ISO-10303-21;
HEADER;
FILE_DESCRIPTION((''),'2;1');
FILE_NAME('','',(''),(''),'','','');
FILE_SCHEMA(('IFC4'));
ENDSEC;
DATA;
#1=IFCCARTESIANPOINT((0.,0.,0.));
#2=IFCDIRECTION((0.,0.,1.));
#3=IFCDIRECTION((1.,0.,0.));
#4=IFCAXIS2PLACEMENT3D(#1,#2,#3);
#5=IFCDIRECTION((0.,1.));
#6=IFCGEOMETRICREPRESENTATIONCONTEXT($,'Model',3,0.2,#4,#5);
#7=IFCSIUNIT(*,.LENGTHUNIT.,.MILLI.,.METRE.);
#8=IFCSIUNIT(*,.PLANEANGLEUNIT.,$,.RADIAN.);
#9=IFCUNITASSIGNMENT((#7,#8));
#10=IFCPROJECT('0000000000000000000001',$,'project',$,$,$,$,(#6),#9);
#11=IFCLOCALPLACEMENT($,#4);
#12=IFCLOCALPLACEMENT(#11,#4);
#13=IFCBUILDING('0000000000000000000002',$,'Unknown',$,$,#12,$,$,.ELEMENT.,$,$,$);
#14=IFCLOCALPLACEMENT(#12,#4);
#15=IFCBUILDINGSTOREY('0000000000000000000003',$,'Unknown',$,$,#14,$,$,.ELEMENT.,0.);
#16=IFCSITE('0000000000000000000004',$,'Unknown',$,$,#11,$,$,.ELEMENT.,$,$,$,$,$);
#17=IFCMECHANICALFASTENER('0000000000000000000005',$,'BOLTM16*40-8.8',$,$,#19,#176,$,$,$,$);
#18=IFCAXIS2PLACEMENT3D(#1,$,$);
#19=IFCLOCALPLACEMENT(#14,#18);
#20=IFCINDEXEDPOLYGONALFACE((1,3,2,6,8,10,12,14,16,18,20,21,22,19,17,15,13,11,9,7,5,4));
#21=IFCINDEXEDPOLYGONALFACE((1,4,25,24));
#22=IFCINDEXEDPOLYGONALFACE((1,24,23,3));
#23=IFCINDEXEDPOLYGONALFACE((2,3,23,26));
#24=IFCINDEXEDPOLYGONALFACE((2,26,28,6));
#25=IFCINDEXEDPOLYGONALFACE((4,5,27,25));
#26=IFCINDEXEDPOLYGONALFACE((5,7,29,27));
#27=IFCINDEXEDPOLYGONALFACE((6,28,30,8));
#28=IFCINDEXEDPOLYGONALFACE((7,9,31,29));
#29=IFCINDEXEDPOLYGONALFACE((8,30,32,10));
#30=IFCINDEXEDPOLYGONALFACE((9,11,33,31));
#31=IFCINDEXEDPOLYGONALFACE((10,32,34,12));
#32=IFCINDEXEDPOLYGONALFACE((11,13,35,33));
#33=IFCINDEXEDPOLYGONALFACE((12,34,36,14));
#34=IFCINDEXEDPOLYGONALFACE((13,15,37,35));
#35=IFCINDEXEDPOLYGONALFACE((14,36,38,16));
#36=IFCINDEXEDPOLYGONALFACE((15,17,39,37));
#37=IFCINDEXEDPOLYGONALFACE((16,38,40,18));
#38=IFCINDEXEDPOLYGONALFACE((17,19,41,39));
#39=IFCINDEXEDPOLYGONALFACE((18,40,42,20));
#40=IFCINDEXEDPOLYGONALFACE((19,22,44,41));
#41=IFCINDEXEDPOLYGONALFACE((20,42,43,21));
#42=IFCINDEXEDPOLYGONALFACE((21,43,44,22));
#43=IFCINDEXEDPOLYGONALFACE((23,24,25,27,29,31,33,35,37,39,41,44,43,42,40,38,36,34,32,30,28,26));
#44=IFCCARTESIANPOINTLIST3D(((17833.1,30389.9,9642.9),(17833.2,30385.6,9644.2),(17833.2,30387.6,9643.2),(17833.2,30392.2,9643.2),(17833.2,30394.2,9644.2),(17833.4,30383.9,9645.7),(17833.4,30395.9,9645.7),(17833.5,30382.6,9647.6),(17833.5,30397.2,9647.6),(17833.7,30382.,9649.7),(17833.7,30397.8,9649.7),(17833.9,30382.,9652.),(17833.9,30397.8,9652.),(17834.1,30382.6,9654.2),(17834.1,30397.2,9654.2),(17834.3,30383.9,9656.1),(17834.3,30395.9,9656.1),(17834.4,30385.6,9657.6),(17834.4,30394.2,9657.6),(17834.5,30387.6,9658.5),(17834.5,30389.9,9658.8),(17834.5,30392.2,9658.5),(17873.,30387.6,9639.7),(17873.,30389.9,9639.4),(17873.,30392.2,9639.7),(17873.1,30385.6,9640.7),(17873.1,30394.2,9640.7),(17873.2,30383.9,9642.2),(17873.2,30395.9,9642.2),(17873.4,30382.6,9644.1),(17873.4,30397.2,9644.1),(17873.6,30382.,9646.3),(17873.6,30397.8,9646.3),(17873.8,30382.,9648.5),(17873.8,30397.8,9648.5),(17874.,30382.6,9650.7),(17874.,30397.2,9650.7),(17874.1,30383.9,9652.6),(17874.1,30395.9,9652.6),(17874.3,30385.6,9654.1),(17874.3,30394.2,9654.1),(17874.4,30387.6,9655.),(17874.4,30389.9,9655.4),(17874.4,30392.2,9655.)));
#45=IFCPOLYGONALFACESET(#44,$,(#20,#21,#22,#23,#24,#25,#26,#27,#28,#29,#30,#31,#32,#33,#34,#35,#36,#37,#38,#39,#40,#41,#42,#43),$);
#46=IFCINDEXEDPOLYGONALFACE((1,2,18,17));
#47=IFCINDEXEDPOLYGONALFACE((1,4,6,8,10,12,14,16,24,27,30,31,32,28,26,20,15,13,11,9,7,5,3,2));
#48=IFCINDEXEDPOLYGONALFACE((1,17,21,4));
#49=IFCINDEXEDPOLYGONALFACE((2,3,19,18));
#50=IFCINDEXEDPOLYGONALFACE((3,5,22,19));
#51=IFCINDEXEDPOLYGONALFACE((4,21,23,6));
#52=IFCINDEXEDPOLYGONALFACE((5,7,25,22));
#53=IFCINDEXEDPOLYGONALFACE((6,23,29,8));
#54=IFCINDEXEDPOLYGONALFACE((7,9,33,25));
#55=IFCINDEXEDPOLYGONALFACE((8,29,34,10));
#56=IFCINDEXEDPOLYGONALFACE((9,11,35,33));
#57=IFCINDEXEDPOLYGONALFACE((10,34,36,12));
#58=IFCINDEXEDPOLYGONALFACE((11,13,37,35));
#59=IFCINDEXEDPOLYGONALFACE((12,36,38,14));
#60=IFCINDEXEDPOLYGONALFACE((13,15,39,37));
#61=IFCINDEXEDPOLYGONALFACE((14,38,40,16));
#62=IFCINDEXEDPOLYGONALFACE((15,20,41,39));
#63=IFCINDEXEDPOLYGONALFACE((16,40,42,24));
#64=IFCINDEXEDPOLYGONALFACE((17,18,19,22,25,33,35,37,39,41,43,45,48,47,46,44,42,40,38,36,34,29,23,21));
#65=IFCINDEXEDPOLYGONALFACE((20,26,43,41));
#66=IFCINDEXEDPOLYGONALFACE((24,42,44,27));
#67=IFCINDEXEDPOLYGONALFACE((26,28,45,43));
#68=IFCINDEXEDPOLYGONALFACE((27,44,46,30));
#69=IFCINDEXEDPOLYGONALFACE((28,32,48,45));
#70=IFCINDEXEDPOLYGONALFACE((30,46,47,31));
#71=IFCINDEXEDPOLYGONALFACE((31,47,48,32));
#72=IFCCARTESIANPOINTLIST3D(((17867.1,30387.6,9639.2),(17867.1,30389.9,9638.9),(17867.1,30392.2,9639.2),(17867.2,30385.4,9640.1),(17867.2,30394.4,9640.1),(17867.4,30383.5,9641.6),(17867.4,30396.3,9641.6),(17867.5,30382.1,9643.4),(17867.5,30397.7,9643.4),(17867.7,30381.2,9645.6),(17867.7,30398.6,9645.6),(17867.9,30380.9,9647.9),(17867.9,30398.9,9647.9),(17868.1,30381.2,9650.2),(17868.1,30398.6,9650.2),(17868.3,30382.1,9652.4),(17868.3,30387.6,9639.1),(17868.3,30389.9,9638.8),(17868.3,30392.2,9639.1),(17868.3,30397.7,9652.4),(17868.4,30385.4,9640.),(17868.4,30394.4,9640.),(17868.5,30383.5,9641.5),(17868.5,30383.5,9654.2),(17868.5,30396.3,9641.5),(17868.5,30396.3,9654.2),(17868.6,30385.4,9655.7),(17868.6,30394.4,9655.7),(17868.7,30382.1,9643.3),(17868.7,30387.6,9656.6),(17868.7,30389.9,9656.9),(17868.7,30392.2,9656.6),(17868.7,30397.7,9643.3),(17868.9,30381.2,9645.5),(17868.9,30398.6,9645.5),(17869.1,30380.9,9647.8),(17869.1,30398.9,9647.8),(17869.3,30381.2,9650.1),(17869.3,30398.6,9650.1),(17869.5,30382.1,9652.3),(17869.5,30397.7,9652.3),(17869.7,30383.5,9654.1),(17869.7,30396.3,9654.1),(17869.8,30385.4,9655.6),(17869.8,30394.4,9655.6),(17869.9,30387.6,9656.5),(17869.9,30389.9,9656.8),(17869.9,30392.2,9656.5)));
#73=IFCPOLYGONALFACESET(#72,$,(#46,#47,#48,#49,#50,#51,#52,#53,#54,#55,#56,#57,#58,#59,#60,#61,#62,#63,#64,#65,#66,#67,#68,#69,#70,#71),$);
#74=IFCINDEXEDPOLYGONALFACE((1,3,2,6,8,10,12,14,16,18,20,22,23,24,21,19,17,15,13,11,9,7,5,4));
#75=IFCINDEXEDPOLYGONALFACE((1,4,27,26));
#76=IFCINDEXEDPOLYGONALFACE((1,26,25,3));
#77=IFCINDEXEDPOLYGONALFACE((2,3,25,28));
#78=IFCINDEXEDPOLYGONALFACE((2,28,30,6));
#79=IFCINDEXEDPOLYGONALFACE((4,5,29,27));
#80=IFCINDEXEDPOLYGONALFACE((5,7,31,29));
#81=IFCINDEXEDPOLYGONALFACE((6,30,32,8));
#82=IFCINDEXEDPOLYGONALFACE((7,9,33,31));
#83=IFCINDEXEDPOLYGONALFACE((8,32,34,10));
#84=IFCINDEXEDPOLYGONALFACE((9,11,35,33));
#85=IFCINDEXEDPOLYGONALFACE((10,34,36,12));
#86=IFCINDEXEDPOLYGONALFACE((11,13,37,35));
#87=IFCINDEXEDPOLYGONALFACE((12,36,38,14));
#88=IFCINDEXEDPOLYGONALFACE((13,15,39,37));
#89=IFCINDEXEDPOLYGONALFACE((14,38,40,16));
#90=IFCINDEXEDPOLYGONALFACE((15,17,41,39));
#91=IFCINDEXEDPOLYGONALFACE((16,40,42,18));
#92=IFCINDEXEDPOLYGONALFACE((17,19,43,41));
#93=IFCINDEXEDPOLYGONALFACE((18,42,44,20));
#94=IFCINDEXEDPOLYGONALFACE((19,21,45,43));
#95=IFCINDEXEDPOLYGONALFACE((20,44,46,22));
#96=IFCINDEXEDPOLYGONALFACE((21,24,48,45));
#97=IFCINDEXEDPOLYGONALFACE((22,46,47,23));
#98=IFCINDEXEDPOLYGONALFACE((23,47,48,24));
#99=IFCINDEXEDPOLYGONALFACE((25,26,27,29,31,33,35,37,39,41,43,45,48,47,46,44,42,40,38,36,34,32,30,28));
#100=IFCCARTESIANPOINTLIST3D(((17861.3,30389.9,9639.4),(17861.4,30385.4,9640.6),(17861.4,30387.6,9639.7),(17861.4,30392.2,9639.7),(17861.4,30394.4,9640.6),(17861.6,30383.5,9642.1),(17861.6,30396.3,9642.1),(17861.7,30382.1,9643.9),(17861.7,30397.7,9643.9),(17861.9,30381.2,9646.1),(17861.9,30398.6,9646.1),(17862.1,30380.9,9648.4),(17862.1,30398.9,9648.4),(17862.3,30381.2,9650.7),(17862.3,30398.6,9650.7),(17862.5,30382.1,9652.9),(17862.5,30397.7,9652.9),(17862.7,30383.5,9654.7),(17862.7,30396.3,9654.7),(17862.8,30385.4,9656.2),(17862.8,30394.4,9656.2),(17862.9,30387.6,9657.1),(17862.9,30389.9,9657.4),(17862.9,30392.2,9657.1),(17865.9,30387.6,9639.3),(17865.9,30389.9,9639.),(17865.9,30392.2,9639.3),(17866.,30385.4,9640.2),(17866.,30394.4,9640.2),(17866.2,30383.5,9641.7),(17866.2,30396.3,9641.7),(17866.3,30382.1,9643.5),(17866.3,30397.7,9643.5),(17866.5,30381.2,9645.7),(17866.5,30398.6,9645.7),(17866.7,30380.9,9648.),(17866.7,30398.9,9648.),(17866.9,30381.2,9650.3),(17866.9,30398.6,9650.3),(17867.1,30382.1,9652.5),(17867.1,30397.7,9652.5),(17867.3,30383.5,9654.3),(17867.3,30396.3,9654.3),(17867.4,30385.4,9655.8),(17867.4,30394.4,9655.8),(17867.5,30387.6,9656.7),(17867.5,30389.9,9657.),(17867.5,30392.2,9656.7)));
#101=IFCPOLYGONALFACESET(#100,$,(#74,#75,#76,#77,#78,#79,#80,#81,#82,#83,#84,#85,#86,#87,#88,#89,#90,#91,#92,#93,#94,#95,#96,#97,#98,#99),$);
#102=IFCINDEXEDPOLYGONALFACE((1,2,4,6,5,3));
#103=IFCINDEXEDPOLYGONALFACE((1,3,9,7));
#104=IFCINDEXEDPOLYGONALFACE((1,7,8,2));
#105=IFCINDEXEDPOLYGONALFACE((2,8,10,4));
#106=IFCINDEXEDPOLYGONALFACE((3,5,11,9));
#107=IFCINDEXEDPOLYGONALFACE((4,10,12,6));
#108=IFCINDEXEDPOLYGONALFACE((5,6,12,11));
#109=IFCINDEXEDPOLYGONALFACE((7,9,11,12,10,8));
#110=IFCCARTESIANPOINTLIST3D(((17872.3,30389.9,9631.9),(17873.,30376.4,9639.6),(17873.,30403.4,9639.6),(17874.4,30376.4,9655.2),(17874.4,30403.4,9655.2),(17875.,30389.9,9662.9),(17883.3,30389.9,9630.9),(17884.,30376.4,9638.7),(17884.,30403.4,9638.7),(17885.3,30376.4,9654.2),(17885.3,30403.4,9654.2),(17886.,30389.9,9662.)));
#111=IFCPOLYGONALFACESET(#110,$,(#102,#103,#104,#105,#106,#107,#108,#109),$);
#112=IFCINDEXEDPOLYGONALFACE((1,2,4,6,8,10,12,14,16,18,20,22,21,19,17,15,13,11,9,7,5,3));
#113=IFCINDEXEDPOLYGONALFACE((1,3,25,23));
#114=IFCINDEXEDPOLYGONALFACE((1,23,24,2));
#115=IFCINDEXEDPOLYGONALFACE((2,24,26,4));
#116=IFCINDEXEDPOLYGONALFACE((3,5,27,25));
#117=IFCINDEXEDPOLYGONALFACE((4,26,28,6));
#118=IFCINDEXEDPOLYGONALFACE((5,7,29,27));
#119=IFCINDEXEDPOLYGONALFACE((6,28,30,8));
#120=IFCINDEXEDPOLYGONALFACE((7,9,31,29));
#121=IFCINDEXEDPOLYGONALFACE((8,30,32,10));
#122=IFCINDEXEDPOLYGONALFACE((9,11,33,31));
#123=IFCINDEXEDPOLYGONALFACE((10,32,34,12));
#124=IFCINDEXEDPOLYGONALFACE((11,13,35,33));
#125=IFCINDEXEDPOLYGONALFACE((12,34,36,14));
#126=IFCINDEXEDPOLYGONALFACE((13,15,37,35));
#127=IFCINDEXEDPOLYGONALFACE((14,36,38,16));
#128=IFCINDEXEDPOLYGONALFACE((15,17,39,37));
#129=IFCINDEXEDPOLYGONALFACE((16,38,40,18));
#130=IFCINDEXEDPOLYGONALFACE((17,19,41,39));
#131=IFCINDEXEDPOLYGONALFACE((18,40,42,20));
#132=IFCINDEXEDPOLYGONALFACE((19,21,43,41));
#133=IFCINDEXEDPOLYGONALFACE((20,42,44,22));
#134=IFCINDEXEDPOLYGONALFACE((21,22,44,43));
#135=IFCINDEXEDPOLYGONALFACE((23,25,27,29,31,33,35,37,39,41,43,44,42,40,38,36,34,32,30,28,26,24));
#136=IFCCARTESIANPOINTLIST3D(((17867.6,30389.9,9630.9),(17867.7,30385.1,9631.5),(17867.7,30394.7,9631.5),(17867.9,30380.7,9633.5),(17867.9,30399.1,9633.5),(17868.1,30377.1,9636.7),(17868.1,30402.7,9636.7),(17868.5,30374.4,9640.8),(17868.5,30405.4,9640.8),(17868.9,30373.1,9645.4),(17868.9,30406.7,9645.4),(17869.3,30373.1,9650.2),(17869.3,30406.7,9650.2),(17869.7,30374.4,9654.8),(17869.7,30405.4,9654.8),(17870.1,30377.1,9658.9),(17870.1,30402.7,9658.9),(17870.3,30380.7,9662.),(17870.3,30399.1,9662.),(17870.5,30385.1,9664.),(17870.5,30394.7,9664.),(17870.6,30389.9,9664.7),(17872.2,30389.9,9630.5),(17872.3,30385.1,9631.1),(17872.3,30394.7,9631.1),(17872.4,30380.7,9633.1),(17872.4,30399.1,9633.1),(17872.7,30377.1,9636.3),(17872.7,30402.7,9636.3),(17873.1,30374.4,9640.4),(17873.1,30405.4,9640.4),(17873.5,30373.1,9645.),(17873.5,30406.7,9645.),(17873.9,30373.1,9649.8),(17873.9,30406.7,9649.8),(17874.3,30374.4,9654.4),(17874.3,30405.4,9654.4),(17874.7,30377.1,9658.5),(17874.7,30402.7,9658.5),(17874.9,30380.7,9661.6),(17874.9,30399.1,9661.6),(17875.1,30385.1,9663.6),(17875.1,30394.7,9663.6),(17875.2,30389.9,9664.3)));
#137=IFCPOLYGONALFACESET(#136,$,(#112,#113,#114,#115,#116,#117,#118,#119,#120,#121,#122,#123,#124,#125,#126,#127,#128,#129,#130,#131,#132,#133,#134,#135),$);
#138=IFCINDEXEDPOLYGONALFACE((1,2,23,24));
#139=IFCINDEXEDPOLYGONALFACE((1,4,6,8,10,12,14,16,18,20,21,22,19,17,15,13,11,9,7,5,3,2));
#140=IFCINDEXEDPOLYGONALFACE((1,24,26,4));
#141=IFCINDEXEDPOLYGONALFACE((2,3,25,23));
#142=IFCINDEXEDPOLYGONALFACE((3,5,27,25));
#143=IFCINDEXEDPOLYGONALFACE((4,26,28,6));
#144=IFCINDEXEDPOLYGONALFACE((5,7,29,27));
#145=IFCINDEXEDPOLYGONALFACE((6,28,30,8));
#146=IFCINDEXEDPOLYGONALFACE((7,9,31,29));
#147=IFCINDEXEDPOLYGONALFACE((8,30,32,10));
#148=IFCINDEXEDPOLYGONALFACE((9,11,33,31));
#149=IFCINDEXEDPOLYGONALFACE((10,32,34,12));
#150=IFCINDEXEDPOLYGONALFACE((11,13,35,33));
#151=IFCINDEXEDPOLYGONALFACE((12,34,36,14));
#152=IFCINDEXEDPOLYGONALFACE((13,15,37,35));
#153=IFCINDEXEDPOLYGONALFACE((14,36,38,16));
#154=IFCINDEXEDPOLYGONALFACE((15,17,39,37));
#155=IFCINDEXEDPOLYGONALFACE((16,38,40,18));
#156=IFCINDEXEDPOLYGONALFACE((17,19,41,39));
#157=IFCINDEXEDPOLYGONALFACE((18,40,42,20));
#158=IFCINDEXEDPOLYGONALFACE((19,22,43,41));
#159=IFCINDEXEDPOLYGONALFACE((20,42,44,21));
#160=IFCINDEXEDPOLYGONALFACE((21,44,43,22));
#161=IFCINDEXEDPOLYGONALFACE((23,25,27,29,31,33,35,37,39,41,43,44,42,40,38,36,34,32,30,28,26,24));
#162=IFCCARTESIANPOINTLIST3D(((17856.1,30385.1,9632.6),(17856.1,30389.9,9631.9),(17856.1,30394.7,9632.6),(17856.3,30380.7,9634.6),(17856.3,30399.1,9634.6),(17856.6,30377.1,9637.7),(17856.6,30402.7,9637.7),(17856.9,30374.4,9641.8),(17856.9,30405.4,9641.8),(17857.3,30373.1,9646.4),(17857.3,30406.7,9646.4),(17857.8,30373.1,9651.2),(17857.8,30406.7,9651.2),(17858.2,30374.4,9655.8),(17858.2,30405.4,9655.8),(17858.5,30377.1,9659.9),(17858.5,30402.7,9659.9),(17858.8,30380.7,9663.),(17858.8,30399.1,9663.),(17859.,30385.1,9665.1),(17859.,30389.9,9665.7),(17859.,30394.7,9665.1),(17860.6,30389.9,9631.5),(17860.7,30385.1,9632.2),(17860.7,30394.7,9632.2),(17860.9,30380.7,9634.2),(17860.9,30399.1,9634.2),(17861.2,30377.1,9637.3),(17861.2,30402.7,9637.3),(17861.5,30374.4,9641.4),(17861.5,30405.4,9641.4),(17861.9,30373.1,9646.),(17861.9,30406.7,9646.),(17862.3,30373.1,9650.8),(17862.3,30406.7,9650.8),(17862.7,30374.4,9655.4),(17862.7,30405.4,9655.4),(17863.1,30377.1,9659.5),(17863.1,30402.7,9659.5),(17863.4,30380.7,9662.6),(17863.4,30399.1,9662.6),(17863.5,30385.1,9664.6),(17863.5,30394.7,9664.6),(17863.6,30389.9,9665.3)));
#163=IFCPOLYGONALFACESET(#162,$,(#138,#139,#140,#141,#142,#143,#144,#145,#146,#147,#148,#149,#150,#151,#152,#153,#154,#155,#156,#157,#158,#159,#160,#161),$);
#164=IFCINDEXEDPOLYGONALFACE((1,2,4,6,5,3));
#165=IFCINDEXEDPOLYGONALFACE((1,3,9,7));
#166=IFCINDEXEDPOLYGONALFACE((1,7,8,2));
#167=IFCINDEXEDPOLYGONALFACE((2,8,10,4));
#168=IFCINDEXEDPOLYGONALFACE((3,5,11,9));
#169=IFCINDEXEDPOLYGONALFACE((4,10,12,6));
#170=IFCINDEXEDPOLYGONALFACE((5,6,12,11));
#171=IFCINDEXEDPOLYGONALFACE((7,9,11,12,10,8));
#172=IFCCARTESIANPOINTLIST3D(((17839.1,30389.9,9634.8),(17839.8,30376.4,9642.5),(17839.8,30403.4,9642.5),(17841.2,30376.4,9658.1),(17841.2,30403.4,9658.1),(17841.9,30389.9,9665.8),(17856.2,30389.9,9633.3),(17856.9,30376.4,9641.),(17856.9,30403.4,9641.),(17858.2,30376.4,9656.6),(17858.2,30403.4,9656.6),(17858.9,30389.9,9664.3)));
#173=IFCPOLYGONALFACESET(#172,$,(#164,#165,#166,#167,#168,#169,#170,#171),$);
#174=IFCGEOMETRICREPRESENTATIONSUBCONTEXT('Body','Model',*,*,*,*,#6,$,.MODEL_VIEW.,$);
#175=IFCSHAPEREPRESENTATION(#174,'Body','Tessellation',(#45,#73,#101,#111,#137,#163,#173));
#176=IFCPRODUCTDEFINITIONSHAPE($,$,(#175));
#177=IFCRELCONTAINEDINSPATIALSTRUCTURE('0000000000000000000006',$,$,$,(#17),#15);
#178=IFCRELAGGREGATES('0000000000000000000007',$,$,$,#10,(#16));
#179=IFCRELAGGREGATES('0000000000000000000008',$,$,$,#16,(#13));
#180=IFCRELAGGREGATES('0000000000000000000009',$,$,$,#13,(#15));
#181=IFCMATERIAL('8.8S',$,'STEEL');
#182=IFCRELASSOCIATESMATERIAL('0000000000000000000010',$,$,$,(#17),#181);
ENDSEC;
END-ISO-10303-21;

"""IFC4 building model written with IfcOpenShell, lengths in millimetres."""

from ifc_helpers import new_model, si_unit, direction, frame, origin_with_axes, place, context, subcontext, project, spatial, line, arc, indexed_curve, outline, extrude, source, transform, mapped, material, element, save


model = new_model("IFC4")

# Units and contexts
model_context = context("Model", 3, precision=0.2, world=origin_with_axes(), true_north=direction((0.0, 1.0)))
body_context = subcontext(model_context, "Body", "Model", "MODEL_VIEW")
ifc_project = project(units=[si_unit("LENGTHUNIT", "METRE", prefix="MILLI"), si_unit("PLANEANGLEUNIT", "RADIAN")], contexts=[model_context])

# Site, building, storey
site_placement = place(None, origin_with_axes())
site = spatial("IfcSite", under=ifc_project, at=site_placement, Name="Unknown", CompositionType="ELEMENT")
building_placement = place(site_placement, origin_with_axes())
building = spatial("IfcBuilding", under=site, at=building_placement, Name="Unknown", CompositionType="ELEMENT")
storey_placement = place(building_placement, origin_with_axes())
storey = spatial("IfcBuildingStorey", under=building, at=storey_placement, Name="Unknown", CompositionType="ELEMENT", Elevation=0.0)

# Mechanical fastener
ifc_material_1 = material(Name="8.8S", Category="STEEL")
shared_shape_1 = source(origin_with_axes(), body_context, "Body", "SweptSolid", [
    extrude(outline(indexed_curve([(8.0, 0.0), (0.0, 8.0), (-8.0, 0.0), (0.0, -8.0)], segments=[arc(1, 2, 3), arc(3, 4, 1)])), frame((0.0, 0.0, 7.0), z_axis=(0.0, 0.0, -1.0), x_axis=(0.0, 1.0, 0.0)), (0.0, 0.0, 1.0), 40.0),
    extrude(outline(indexed_curve([(0.0, 9.0), (6.4, 6.4), (9.0, 0.0), (6.4, -6.4), (0.0, -9.0), (-0.8, -9.0), (-9.0, 0.0), (-6.4, 6.4)], segments=[arc(1, 2, 3), arc(3, 4, 5), arc(5, 6, 7), arc(7, 8, 1)])), frame((0.0, 0.0, 2.4), z_axis=(0.0, 0.0, -1.0), x_axis=(0.0, 1.0, 0.0)), (0.0, 0.0, 1.0), 1.2),
    extrude(outline(indexed_curve([(0.0, 9.0), (6.4, 6.4), (9.0, 0.0), (6.4, -6.4), (0.0, -9.0), (-0.8, -9.0), (-9.0, 0.0), (-6.4, 6.4)], segments=[arc(1, 2, 3), arc(3, 4, 5), arc(5, 6, 7), arc(7, 8, 1)])), frame((0.0, 0.0, 0.0), z_axis=(0.0, 0.0, -1.0), x_axis=(0.0, 1.0, 0.0)), (0.0, 0.0, 1.0), 4.6),
    extrude(outline(indexed_curve([(15.6, 0.0), (7.8, 13.5), (-7.8, 13.5), (-15.6, 0.0), (-7.8, -13.5), (7.8, -13.5)], segments=[line(1, 2, 3, 4, 5, 6, 1)])), frame((0.0, 0.0, 18.0), z_axis=(0.0, 0.0, -1.0), x_axis=(0.0, 1.0, 0.0)), (0.0, 0.0, 1.0), 11.0),
    extrude(outline(indexed_curve([(17.0, 0.0), (0.0, 17.0), (-17.0, 0.0), (0.0, -17.0)], segments=[arc(1, 2, 3), arc(3, 4, 1)])), frame((0.0, 0.0, 7.0), z_axis=(0.0, 0.0, -1.0), x_axis=(0.0, 1.0, 0.0)), (0.0, 0.0, 1.0), 4.6),
    extrude(outline(indexed_curve([(17.0, 0.0), (0.0, 17.0), (-17.0, 0.0), (0.0, -17.0)], segments=[arc(1, 2, 3), arc(3, 4, 1)])), frame((0.0, 0.0, -4.6), z_axis=(0.0, 0.0, -1.0), x_axis=(0.0, 1.0, 0.0)), (0.0, 0.0, 1.0), 4.6),
    extrude(outline(indexed_curve([(15.6, 0.0), (7.8, 13.5), (-7.8, 13.5), (-15.6, 0.0), (-7.8, -13.5), (7.8, -13.5)], segments=[line(1, 2, 3, 4, 5, 6, 1)])), frame((0.0, 0.0, -9.2), z_axis=(0.0, 0.0, -1.0), x_axis=(0.0, 1.0, 0.0)), (0.0, 0.0, 1.0), 17.1),
])
mechanical_fastener_1_placement = place(storey_placement, frame((17866.7, 30389.9, 9648.0), z_axis=(0.996195, 0.0, -0.087156), x_axis=(0.0, 1.0, 0.0)))
element("IfcMechanicalFastener", 1, at=mechanical_fastener_1_placement, inside=storey, material=ifc_material_1, Name="BOLTM16*40-8.8", context=body_context, shape_type="MappedRepresentation", body=[
    mapped(shared_shape_1, transform((0.0, 0.0, 0.0))),
])

save(model, "model.ifc")
